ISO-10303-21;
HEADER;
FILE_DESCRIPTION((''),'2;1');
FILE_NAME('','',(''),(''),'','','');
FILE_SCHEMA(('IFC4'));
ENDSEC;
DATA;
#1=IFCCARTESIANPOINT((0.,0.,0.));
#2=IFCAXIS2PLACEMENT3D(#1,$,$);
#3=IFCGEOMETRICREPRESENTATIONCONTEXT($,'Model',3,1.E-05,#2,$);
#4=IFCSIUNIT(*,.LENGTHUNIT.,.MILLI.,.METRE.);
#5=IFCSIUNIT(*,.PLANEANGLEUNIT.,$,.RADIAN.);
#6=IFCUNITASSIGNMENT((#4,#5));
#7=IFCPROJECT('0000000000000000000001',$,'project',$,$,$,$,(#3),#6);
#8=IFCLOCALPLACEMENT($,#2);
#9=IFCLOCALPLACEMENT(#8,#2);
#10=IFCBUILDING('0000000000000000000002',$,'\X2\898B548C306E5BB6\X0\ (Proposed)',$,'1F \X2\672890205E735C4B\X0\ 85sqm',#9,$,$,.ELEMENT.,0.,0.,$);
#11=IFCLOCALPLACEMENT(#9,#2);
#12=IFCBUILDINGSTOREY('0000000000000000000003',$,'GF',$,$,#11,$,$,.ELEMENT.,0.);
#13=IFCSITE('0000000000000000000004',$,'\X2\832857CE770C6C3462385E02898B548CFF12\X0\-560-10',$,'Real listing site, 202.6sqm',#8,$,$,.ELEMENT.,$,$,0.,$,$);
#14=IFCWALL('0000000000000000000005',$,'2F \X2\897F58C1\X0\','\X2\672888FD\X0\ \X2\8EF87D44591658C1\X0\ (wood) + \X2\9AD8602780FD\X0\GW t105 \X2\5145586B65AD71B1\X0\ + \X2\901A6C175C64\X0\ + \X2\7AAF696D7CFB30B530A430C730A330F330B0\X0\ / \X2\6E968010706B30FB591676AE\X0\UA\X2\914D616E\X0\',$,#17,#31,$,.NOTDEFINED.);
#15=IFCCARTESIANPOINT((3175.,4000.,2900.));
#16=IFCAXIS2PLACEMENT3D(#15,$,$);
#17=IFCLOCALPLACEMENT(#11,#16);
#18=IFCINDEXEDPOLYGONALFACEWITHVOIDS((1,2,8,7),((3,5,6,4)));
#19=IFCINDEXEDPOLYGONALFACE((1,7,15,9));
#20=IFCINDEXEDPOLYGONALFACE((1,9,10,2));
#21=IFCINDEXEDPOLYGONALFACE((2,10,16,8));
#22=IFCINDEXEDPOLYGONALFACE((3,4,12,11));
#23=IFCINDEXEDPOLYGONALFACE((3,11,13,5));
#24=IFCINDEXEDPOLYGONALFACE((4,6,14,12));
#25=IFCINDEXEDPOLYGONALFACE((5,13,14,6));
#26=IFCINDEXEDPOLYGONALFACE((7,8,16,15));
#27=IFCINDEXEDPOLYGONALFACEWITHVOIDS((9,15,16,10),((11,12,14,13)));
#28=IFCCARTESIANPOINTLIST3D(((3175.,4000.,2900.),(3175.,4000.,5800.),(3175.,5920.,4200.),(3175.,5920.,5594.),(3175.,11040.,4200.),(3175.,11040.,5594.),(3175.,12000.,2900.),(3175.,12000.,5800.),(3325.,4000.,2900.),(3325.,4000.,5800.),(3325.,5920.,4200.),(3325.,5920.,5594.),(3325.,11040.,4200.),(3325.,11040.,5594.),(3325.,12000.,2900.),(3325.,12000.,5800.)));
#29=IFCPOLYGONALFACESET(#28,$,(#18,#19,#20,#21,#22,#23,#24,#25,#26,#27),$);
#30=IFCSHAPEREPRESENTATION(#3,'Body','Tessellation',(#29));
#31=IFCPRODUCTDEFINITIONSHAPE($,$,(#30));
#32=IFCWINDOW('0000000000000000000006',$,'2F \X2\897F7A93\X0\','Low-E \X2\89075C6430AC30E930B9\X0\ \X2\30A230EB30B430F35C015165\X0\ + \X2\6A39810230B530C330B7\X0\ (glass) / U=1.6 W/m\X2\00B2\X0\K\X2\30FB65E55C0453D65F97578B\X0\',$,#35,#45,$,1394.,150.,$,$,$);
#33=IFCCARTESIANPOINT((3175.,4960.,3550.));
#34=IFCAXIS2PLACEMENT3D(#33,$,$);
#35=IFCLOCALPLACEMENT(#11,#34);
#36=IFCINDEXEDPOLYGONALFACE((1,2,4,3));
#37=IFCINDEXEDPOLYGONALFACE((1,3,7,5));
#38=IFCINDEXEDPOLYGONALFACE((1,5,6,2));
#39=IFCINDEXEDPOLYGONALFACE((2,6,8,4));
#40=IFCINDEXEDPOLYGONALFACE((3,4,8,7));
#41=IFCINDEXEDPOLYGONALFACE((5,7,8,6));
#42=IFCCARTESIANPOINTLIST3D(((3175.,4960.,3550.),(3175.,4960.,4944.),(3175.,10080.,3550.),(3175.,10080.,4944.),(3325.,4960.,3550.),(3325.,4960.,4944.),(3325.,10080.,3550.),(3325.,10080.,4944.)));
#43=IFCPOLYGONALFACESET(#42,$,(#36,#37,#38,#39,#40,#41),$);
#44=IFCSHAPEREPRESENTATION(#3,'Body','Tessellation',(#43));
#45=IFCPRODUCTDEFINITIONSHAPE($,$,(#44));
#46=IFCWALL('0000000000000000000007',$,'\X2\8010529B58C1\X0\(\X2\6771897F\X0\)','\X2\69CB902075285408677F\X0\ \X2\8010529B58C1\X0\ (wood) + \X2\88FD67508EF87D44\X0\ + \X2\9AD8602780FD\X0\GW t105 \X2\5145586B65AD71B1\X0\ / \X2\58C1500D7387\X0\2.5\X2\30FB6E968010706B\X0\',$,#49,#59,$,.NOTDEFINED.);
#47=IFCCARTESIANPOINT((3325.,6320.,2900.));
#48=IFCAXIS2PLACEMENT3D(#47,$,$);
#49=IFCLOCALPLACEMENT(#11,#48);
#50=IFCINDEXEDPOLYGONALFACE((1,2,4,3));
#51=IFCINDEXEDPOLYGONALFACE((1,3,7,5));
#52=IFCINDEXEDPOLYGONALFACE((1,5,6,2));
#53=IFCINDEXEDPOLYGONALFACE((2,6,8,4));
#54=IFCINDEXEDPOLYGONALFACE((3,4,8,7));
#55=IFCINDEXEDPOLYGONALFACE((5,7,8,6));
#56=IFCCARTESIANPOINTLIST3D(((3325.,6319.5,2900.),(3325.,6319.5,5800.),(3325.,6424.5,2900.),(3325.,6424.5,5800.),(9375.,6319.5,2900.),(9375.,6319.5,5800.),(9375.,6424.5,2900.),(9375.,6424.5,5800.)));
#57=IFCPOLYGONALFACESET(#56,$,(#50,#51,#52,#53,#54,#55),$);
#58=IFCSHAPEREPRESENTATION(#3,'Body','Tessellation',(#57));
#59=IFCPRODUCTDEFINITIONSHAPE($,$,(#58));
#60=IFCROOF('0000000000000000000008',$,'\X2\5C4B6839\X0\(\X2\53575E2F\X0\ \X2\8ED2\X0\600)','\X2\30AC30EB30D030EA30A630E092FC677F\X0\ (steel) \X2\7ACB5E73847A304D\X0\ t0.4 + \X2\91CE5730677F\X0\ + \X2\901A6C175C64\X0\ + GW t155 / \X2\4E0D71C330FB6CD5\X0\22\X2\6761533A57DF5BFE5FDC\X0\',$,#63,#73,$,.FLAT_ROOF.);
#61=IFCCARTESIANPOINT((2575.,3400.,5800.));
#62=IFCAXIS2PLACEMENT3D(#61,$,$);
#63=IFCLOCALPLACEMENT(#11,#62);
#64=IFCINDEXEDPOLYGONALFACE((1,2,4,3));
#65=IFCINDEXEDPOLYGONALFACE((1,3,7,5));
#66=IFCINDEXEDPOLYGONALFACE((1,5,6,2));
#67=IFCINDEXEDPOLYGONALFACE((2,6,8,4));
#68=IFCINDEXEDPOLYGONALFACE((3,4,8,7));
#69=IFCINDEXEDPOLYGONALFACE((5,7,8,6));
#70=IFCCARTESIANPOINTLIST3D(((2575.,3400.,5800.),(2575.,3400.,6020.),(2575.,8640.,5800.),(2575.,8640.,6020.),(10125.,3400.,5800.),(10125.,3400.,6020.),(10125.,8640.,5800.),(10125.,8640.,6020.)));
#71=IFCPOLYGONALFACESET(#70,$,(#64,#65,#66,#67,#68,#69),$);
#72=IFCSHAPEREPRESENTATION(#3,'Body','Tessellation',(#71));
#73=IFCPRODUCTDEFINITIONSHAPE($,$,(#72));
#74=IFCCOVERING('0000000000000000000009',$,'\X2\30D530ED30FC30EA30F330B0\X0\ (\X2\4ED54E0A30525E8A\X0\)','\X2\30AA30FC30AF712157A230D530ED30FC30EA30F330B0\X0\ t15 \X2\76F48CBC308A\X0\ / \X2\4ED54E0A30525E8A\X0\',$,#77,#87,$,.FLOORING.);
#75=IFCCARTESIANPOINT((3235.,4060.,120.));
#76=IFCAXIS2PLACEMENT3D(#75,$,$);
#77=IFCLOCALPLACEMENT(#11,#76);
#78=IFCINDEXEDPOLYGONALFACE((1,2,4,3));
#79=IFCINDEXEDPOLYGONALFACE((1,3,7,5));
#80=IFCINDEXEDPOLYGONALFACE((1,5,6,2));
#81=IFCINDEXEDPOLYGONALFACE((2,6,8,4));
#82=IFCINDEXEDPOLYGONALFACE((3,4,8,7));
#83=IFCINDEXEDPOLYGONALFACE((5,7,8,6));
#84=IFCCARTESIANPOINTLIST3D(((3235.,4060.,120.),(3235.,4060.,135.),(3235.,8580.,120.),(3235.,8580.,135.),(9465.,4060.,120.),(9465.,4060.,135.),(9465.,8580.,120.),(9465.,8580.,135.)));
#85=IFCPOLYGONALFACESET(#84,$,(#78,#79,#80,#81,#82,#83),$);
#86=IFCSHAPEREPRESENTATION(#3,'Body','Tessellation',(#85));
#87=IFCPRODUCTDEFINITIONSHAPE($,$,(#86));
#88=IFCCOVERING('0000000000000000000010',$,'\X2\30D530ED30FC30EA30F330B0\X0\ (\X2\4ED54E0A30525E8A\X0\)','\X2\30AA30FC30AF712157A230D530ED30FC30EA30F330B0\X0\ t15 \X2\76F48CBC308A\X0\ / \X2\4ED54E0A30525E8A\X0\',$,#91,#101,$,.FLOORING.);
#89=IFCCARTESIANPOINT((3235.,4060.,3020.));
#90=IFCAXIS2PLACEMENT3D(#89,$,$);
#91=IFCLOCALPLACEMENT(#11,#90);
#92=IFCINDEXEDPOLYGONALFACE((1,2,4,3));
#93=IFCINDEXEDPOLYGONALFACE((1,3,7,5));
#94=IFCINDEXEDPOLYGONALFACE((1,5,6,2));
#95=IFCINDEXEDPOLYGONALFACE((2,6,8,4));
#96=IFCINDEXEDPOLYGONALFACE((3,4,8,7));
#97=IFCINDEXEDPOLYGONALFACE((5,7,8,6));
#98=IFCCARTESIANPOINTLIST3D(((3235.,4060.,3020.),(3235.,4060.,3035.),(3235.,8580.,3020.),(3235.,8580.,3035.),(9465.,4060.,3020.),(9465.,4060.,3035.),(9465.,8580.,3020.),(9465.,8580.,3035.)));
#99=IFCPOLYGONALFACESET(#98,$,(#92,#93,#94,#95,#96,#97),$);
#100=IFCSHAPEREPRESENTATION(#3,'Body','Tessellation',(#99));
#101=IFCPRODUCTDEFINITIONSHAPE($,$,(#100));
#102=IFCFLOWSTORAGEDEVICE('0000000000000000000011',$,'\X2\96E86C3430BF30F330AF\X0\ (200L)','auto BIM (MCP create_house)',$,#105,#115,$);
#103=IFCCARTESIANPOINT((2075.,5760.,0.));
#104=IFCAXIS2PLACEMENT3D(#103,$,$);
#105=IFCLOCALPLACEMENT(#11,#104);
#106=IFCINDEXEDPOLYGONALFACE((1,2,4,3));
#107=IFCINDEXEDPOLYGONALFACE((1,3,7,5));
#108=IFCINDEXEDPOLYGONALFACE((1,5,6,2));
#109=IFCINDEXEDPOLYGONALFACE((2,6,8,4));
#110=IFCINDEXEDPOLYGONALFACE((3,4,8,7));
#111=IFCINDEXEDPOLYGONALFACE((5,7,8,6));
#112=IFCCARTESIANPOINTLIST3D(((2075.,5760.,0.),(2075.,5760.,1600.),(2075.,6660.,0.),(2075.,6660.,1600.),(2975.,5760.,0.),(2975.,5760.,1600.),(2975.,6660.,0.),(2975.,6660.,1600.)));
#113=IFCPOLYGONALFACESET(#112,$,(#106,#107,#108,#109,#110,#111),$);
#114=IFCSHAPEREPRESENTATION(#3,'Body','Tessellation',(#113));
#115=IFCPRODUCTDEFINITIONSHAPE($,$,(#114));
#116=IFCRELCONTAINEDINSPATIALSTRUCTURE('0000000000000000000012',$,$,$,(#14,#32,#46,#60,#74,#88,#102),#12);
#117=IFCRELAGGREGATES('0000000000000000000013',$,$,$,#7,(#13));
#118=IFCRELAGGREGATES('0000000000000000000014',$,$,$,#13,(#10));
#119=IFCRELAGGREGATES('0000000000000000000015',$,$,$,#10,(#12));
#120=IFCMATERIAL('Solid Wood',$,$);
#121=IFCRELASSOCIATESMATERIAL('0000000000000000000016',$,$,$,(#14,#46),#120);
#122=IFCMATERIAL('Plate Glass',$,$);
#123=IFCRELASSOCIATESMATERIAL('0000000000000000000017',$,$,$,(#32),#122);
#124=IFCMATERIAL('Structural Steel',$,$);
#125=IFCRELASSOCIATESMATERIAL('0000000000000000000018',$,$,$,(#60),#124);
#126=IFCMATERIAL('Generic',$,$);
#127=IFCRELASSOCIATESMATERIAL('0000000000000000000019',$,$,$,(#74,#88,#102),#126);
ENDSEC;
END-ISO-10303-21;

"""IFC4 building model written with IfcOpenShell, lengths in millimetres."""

from ifc_helpers import new_model, si_unit, frame, frame_2d, origin, place, context, project, spatial, rectangle, extrude, material, element, fill, save


model = new_model("IFC4")

# Units and contexts
model_context = context("Model", 3, precision=1e-05, world=origin())
ifc_project = project(units=[si_unit("LENGTHUNIT", "METRE", prefix="MILLI"), si_unit("PLANEANGLEUNIT", "RADIAN")], contexts=[model_context])

# Site, building, storey
site_placement = place(None, origin())
site = spatial("IfcSite", under=ifc_project, at=site_placement, Name="茨城県水戸市見和２-560-10", ObjectType="Real listing site, 202.6sqm", CompositionType="ELEMENT", RefElevation=0.0)
building_placement = place(site_placement, origin())
building = spatial("IfcBuilding", under=site, at=building_placement, Name="見和の家 (Proposed)", ObjectType="1F 木造平屋 85sqm", CompositionType="ELEMENT", ElevationOfRefHeight=0.0, ElevationOfTerrain=0.0)
storey_placement = place(building_placement, origin())
storey = spatial("IfcBuildingStorey", under=building, at=storey_placement, Name="GF", CompositionType="ELEMENT", Elevation=0.0)

# Shared definitions
ifc_material_1 = material(Name="Solid Wood")
ifc_material_2 = material(Name="Generic")

# Shared definitions
ifc_material_3 = material(Name="Plate Glass")

# Wall, opening, window
wall_1_placement = place(storey_placement, frame((3175.0, 4000.0, 2900.0)))
wall_1 = element("IfcWall", 1, at=wall_1_placement, inside=storey, material=ifc_material_1, Name="2F 西壁", Description="木製 軸組外壁 (wood) + 高性能GW t105 充填断熱 + 通気層 + 窯業系サイディング / 準耐火・外皮UA配慮", PredefinedType="NOTDEFINED", context=model_context, shape_type="SweptSolid", body=[
    extrude(rectangle(XDim=150.0, YDim=8000.0, at=frame_2d((75.0, 4000.0))), frame((3175.0, 4000.0, 2900.0)), (0.0, 0.0, 1.0), 2900.0),
])
opening_1_placement = place(storey_placement, frame((3175.0, 4960.0, 3550.0)))
opening_1 = element("IfcOpeningElement", 2, at=opening_1_placement, cuts=wall_1, PredefinedType="NOTDEFINED", context=model_context, shape_type="SweptSolid", body=[
    extrude(rectangle(XDim=150.0, YDim=5120.0, at=frame_2d((75.0, 2560.0))), frame((3175.0, 4960.0, 3550.0)), (0.0, 0.0, 1.0), 1394.0),
])
window_1_placement = place(storey_placement, frame((3175.0, 4960.0, 3550.0)))
window_1 = element("IfcWindow", 3, at=window_1_placement, inside=storey, material=ifc_material_3, Name="2F 西窓", Description="Low-E 複層ガラス アルゴン封入 + 樹脂サッシ (glass) / U=1.6 W/m²K・日射取得型", OverallHeight=1394.0, OverallWidth=150.0, context=model_context, shape_type="SweptSolid", body=[
    extrude(rectangle(XDim=150.0, YDim=5120.0, at=frame_2d((75.0, 2560.0))), frame((3175.0, 4960.0, 3550.0)), (0.0, 0.0, 1.0), 1394.0),
])
fill(opening_1, window_1)

# Wall
wall_2_placement = place(storey_placement, frame((3325.0, 6320.0, 2900.0)))
element("IfcWall", 4, at=wall_2_placement, inside=storey, material=ifc_material_1, Name="耐力壁(東西)", Description="構造用合板 耐力壁 (wood) + 製材軸組 + 高性能GW t105 充填断熱 / 壁倍率2.5・準耐火", PredefinedType="NOTDEFINED", context=model_context, shape_type="SweptSolid", body=[
    extrude(rectangle(XDim=6050.0, YDim=105.0, at=frame_2d((3025.0, 52.0))), frame((3325.0, 6320.0, 2900.0)), (0.0, 0.0, 1.0), 2900.0),
])

# Roof
ifc_material_4 = material(Name="Structural Steel")
for number, where, name in (
    (5, (2575.0, 3400.0, 5800.0), "屋根(南帯 軒600)"),
):
    element("IfcRoof", number, at=place(storey_placement, frame(where)), inside=storey, material=ifc_material_4, Name=name, Description="ガルバリウム鋼板 (steel) 立平葺き t0.4 + 野地板 + 通気層 + GW t155 / 不燃・法22条区域対応", PredefinedType="FLAT_ROOF", context=model_context, shape_type="SweptSolid", body=[
        extrude(rectangle(XDim=7550.0, YDim=5240.0, at=frame_2d((3775.0, 2620.0))), frame((2575.0, 3400.0, 5800.0)), (0.0, 0.0, 1.0), 220.0),
    ])

# Coverings
covering_1_placement = place(storey_placement, frame((3235.0, 4060.0, 120.0)))
element("IfcCovering", 6, at=covering_1_placement, inside=storey, material=ifc_material_2, Name="フローリング (仕上げ床)", Description="オーク無垢フローリング t15 直貼り / 仕上げ床", PredefinedType="FLOORING", context=model_context, shape_type="SweptSolid", body=[
    extrude(rectangle(XDim=6230.0, YDim=4520.0, at=frame_2d((3115.0, 2260.0))), frame((3235.0, 4060.0, 120.0)), (0.0, 0.0, 1.0), 15.0),
])
covering_2_placement = place(storey_placement, frame((3235.0, 4060.0, 3020.0)))
element("IfcCovering", 7, at=covering_2_placement, inside=storey, material=ifc_material_2, Name="フローリング (仕上げ床)", Description="オーク無垢フローリング t15 直貼り / 仕上げ床", PredefinedType="FLOORING", context=model_context, shape_type="SweptSolid", body=[
    extrude(rectangle(XDim=6230.0, YDim=4520.0, at=frame_2d((3115.0, 2260.0))), frame((3235.0, 4060.0, 3020.0)), (0.0, 0.0, 1.0), 15.0),
])

# Flow storage device
flow_storage_device_placement = place(storey_placement, frame((2075.0, 5760.0, 0.0)))
element("IfcFlowStorageDevice", 8, at=flow_storage_device_placement, inside=storey, material=ifc_material_2, Name="雨水タンク (200L)", Description="auto BIM (MCP create_house)", context=model_context, shape_type="SweptSolid", body=[
    extrude(rectangle(XDim=900.0, YDim=900.0, at=frame_2d((450.0, 450.0))), frame((2075.0, 5760.0, 0.0)), (0.0, 0.0, 1.0), 1600.0),
])

save(model, "model.ifc")
